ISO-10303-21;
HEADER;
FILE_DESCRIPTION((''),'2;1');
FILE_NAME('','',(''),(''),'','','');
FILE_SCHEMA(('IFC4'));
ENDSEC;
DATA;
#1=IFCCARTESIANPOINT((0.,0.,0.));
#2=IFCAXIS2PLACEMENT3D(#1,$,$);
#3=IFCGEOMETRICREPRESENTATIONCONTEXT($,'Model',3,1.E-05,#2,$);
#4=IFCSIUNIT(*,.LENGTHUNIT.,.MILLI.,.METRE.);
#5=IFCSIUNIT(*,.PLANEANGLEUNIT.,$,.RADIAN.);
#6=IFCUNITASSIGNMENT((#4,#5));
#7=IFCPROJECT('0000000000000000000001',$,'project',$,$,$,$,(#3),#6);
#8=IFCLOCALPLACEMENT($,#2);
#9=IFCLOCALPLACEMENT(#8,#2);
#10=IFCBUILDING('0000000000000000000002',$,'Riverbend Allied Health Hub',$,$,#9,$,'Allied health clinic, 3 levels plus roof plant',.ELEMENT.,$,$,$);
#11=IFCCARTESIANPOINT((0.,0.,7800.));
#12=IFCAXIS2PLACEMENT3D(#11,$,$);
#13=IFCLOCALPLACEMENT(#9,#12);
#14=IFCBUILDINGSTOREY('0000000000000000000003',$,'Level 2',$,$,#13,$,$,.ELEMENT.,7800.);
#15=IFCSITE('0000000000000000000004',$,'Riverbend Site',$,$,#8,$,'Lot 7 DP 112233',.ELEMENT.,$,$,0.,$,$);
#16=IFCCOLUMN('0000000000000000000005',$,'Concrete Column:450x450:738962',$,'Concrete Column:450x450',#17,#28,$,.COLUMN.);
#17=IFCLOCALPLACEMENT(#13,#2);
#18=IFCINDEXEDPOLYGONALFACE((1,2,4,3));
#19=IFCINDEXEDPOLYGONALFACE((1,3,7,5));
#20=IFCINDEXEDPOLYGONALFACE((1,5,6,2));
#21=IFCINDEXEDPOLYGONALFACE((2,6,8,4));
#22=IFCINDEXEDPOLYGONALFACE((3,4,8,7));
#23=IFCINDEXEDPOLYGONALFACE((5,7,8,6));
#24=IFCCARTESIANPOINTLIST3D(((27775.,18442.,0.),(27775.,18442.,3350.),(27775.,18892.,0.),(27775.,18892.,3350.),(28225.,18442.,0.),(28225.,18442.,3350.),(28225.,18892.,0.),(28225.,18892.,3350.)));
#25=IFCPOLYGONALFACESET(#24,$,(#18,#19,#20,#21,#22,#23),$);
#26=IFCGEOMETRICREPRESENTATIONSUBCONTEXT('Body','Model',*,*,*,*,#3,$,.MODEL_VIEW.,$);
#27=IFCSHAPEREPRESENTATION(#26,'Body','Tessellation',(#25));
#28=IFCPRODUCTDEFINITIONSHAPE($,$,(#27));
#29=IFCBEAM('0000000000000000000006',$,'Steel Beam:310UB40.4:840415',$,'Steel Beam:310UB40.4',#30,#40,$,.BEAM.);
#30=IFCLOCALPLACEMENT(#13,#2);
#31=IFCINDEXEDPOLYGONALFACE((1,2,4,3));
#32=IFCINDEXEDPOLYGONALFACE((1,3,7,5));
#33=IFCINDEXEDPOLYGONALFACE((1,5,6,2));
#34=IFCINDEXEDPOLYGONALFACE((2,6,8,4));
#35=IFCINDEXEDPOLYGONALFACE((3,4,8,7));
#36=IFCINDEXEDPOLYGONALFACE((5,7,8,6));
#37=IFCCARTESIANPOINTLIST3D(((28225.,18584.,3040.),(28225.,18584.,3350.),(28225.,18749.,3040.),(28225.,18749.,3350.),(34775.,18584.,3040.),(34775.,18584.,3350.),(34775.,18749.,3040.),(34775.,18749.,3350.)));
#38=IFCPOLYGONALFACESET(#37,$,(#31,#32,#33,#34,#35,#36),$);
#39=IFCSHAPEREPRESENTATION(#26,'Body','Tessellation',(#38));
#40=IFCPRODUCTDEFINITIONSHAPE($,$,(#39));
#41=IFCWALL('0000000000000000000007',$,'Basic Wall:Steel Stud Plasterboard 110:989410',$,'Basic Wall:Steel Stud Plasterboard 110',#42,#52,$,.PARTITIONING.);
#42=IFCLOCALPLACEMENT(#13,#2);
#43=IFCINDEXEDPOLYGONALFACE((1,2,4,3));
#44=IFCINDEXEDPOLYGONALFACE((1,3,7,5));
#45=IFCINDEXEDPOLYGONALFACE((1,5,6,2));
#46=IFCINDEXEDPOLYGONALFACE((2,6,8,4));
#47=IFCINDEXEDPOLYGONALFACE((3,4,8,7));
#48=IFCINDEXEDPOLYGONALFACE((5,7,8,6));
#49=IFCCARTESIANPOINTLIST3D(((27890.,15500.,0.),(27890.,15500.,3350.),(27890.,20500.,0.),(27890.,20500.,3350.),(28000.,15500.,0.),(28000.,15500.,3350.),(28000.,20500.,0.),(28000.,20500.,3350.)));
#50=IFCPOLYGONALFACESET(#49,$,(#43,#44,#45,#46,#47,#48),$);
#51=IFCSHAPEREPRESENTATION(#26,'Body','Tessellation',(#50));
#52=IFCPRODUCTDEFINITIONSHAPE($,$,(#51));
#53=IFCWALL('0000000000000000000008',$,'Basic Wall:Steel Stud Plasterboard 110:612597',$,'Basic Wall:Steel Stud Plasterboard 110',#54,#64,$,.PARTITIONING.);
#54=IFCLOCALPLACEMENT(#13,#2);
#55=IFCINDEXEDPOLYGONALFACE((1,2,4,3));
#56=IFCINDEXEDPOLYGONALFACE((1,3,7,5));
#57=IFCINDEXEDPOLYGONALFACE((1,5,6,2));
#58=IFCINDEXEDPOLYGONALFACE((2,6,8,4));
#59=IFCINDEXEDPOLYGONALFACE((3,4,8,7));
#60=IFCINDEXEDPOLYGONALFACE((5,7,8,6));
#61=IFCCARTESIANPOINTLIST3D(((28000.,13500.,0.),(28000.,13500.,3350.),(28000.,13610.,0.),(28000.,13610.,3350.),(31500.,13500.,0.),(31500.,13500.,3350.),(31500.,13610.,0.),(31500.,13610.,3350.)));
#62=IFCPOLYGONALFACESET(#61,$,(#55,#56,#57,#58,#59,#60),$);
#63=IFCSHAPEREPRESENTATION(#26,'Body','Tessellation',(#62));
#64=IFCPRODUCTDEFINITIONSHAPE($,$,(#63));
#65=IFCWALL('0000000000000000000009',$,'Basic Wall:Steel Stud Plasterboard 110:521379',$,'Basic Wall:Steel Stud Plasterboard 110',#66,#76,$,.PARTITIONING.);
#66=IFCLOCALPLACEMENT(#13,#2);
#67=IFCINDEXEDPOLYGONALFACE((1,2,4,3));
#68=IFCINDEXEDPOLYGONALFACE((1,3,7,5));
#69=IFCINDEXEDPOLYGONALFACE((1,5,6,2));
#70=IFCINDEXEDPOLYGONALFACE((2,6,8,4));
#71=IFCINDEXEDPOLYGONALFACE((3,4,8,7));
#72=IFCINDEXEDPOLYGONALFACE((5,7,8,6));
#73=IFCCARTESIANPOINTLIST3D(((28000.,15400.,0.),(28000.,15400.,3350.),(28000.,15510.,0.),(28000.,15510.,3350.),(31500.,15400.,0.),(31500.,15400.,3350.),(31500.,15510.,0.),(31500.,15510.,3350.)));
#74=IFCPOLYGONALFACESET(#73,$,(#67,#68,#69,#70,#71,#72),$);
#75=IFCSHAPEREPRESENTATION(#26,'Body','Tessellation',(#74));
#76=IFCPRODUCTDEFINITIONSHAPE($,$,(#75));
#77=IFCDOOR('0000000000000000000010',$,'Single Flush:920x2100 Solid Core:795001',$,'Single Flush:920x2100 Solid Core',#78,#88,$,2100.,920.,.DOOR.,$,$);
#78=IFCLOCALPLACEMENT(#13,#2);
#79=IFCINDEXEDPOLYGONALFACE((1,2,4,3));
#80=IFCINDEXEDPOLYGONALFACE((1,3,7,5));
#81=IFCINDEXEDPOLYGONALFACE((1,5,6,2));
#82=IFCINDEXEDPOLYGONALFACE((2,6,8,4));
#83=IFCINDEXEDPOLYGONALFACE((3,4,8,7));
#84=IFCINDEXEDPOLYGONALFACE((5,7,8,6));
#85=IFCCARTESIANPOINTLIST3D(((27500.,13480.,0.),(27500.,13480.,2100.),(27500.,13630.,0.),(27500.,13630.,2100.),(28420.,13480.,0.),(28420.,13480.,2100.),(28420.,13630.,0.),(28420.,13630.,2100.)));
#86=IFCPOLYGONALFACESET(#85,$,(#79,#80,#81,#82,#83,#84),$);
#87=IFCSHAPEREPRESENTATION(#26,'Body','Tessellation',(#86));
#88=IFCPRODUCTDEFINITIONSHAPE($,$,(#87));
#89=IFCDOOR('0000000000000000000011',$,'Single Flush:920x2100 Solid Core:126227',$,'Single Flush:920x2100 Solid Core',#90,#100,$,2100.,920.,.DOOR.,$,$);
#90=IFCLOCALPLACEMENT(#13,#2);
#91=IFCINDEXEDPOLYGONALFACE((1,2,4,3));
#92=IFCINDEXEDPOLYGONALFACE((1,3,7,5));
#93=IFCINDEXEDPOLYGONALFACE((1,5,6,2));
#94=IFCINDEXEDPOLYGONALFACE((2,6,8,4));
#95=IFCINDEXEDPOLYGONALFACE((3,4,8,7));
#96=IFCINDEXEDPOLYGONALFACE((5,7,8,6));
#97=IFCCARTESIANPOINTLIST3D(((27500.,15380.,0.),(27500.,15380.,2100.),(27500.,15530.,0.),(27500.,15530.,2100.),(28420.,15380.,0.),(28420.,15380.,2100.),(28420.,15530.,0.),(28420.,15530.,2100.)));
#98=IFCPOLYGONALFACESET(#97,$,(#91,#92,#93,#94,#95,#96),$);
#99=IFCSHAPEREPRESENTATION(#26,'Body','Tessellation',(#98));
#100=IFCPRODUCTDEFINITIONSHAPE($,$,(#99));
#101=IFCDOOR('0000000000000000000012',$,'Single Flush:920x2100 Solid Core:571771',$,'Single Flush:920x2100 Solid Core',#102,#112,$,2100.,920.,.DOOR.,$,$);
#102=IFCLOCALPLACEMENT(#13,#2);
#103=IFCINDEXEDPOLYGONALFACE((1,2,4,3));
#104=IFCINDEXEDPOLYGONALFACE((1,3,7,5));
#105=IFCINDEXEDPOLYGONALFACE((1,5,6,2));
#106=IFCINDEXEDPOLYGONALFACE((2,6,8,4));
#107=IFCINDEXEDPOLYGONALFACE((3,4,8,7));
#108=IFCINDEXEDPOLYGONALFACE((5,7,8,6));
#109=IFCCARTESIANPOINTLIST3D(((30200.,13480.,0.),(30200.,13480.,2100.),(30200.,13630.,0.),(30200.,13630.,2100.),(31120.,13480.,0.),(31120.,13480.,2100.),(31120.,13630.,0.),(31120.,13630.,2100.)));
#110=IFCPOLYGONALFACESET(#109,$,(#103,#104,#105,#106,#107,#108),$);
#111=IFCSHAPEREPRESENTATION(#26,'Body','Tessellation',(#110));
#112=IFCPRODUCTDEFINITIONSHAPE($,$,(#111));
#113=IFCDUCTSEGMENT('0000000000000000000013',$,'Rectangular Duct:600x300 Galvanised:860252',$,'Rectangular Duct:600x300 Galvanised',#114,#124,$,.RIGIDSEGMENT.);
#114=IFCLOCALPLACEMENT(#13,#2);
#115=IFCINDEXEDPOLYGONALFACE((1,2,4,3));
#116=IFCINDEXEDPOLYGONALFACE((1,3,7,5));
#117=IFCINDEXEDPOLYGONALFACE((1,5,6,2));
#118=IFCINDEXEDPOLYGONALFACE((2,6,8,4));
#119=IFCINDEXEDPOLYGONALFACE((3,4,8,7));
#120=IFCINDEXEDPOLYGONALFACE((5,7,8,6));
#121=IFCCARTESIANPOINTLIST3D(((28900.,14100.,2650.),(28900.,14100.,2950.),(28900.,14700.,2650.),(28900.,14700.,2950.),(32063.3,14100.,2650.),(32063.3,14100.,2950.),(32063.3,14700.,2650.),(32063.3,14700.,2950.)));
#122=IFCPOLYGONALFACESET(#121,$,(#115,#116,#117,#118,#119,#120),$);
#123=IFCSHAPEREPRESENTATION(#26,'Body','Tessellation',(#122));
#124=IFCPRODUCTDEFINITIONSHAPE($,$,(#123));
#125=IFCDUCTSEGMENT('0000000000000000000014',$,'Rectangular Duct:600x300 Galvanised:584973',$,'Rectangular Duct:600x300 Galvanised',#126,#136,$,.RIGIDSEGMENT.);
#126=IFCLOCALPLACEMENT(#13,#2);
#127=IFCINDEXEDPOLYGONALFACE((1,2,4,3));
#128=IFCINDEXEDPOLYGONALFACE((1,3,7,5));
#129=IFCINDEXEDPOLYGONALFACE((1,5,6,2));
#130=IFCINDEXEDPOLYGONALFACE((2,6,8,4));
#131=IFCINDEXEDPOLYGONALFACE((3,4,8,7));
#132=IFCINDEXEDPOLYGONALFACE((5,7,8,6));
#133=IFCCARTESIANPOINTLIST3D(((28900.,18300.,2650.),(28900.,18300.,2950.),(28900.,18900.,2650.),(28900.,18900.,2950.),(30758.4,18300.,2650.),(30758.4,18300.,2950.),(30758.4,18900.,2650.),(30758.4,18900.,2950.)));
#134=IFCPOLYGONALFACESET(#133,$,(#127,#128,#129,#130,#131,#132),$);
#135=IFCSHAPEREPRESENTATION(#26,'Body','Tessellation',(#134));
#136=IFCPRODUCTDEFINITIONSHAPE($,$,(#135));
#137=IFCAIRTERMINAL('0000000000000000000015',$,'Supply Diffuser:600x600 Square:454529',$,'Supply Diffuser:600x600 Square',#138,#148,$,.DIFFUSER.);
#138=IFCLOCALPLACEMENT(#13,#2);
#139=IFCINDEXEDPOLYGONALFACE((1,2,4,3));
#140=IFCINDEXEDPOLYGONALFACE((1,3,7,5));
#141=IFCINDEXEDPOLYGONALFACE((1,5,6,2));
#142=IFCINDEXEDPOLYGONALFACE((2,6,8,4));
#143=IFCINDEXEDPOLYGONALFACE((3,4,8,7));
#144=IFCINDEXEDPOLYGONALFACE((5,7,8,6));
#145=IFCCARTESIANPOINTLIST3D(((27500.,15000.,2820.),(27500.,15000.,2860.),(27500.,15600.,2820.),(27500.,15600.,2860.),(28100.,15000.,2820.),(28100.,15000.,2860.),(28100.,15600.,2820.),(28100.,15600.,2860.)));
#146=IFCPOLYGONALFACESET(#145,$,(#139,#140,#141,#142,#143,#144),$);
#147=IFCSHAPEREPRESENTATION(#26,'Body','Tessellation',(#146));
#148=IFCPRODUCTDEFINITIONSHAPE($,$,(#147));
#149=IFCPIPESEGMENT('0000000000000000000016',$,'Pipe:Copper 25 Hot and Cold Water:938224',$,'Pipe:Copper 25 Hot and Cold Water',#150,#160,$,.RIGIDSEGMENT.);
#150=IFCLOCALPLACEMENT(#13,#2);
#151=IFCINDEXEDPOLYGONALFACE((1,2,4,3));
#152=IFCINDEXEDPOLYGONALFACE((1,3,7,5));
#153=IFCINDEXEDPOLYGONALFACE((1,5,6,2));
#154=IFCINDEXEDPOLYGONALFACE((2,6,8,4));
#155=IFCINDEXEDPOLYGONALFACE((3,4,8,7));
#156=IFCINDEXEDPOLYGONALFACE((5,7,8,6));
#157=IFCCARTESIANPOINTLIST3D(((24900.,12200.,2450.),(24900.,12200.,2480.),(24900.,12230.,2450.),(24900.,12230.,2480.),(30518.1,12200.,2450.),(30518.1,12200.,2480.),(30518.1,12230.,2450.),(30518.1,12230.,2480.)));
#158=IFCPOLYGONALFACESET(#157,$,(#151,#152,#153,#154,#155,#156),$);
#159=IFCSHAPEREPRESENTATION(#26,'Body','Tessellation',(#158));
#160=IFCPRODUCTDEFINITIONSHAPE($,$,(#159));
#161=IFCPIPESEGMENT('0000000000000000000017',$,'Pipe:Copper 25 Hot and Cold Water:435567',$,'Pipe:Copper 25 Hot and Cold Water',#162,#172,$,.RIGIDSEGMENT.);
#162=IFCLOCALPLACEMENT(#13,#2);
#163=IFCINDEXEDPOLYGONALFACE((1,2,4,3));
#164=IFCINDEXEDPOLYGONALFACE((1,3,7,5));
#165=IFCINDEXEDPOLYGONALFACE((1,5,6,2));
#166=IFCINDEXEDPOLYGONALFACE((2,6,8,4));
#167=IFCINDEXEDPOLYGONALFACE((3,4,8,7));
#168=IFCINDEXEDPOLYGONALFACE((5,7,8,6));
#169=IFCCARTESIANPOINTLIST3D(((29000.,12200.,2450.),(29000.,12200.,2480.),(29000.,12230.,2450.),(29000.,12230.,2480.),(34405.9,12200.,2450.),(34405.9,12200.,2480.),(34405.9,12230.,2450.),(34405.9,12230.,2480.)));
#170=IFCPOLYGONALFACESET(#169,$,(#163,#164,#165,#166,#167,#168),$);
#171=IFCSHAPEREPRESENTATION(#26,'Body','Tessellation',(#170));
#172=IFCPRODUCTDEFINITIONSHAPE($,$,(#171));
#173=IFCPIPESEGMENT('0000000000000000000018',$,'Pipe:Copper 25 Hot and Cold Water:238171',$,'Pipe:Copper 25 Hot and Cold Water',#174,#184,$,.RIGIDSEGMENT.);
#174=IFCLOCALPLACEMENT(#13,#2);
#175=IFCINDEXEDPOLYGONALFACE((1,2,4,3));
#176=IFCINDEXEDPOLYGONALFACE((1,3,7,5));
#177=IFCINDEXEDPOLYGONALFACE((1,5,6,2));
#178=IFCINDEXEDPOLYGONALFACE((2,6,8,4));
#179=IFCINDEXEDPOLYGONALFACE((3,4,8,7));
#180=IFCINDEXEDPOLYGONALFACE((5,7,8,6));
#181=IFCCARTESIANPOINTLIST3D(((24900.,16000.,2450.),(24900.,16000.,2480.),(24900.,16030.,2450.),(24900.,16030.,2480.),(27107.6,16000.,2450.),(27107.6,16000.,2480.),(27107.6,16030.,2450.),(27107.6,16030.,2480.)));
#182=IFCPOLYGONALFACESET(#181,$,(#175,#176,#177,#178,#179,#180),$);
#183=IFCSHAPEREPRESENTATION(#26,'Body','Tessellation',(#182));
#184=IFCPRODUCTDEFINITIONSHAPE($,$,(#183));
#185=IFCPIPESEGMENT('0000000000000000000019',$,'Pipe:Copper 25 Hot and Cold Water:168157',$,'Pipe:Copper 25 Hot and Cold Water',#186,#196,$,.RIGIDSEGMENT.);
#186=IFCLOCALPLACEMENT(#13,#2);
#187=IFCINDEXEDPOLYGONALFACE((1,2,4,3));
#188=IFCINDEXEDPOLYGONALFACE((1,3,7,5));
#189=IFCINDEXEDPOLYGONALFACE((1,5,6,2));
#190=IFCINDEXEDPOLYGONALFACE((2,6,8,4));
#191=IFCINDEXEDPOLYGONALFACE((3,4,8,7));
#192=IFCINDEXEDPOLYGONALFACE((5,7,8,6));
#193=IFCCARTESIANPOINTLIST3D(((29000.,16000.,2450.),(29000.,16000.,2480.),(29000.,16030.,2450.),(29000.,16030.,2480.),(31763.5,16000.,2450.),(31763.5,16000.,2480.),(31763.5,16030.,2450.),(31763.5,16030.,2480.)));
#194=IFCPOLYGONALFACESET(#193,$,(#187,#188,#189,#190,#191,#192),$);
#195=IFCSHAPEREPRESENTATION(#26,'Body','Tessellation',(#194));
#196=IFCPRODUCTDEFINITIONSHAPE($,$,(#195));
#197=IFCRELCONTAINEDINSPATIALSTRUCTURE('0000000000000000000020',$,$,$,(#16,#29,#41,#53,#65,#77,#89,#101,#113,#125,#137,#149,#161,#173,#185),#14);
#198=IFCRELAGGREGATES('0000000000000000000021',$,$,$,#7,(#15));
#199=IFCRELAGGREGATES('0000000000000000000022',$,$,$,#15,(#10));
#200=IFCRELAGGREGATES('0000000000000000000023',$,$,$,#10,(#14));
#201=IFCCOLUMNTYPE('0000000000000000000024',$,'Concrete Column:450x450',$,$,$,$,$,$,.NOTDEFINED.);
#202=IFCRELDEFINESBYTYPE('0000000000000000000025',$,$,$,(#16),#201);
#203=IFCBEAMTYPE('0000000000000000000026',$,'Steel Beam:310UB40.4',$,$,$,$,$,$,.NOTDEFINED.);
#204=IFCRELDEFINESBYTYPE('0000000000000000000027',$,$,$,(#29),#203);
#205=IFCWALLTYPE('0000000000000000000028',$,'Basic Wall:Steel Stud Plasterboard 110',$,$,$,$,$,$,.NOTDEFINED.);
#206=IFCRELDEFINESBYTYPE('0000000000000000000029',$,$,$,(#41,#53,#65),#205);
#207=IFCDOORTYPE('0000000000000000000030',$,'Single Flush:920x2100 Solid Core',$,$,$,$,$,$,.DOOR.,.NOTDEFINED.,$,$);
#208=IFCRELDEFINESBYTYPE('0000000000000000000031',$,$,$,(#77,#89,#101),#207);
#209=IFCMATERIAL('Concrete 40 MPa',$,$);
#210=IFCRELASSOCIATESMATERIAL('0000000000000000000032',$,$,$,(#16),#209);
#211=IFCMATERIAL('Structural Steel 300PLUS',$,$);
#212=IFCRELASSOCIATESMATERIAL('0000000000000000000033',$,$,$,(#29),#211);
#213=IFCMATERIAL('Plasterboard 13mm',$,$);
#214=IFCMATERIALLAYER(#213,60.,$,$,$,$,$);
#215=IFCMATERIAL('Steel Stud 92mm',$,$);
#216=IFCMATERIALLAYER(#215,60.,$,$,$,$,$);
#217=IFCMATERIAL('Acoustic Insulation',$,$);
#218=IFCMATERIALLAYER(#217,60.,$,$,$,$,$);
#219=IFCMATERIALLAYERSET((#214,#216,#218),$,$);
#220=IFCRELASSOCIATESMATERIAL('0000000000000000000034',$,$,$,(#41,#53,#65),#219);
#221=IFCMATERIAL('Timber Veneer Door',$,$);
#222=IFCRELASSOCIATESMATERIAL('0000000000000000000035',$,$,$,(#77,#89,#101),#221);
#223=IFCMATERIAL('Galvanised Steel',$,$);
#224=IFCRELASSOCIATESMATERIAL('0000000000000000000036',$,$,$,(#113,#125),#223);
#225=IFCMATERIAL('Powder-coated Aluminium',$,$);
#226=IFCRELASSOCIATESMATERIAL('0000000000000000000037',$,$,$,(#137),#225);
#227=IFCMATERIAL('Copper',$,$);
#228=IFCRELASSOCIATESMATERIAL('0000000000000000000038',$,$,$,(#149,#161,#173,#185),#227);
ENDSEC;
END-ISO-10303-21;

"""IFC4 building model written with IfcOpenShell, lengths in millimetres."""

from ifc_helpers import new_model, si_unit, frame, frame_2d, origin, place, context, subcontext, project, spatial, rectangle, extrude, material, layer, layer_set, layer_usage, type_object, element, save


model = new_model("IFC4")

# Units and contexts
model_context = context("Model", 3, precision=1e-05, world=origin())
body_context = subcontext(model_context, "Body", "Model", "MODEL_VIEW")
ifc_project = project(units=[si_unit("LENGTHUNIT", "METRE", prefix="MILLI"), si_unit("PLANEANGLEUNIT", "RADIAN")], contexts=[model_context])

# Site, building, storey
site_placement = place(None, origin())
site = spatial("IfcSite", under=ifc_project, at=site_placement, Name="Riverbend Site", LongName="Lot 7 DP 112233", CompositionType="ELEMENT", RefElevation=0.0)
building_placement = place(site_placement, origin())
building = spatial("IfcBuilding", under=site, at=building_placement, Name="Riverbend Allied Health Hub", LongName="Allied health clinic, 3 levels plus roof plant", CompositionType="ELEMENT")
storey_placement = place(building_placement, frame((0.0, 0.0, 7800.0)))
storey = spatial("IfcBuildingStorey", under=building, at=storey_placement, Name="Level 2", CompositionType="ELEMENT", Elevation=7800.0)

# Column
ifc_material_1 = material(Name="Concrete 40 MPa")
column_type = type_object("IfcColumnType", Name="Concrete Column:450x450", PredefinedType="NOTDEFINED")
column_placement = place(storey_placement, frame((27775.0, 18442.0, 0.0)))
element("IfcColumn", 1, at=column_placement, inside=storey, type_object=column_type, material=ifc_material_1, Name="Concrete Column:450x450:738962", ObjectType="Concrete Column:450x450", PredefinedType="COLUMN", context=body_context, shape_type="SweptSolid", body=[
    extrude(rectangle(XDim=450.0, YDim=450.0, at=frame_2d((225.0, 225.0))), origin(), (0.0, 0.0, 1.0), 3350.0),
])

# Beam
ifc_material_2 = material(Name="Structural Steel 300PLUS")
beam_type = type_object("IfcBeamType", Name="Steel Beam:310UB40.4", PredefinedType="NOTDEFINED")
beam_placement = place(storey_placement, frame((28225.0, 18584.0, 3040.0)))
element("IfcBeam", 2, at=beam_placement, inside=storey, type_object=beam_type, material=ifc_material_2, Name="Steel Beam:310UB40.4:840415", ObjectType="Steel Beam:310UB40.4", PredefinedType="BEAM", context=body_context, shape_type="SweptSolid", body=[
    extrude(rectangle(XDim=6550.0, YDim=165.0, at=frame_2d((3275.0, 82.5))), origin(), (0.0, 0.0, 1.0), 310.0),
])

# Walls
ifc_material_3 = material(Name="Plasterboard 13mm")
ifc_layer_1 = layer(ifc_material_3, 60.0)
ifc_material_4 = material(Name="Steel Stud 92mm")
ifc_layer_2 = layer(ifc_material_4, 60.0)
ifc_material_5 = material(Name="Acoustic Insulation")
ifc_layer_3 = layer(ifc_material_5, 60.0)
ifc_layer_set = layer_set([ifc_layer_1, ifc_layer_2, ifc_layer_3])
ifc_layer_usage = layer_usage(ifc_layer_set, "AXIS2", "POSITIVE", 0.0)
wall_type = type_object("IfcWallType", Name="Basic Wall:Steel Stud Plasterboard 110", PredefinedType="NOTDEFINED")
wall_placement = place(storey_placement, frame((28000.0, 15500.0, 0.0), z_axis=(0.0, 0.0, 1.0), x_axis=(0.0, 1.0, 0.0)))
element("IfcWall", 3, at=wall_placement, inside=storey, type_object=wall_type, material=ifc_layer_usage, Name="Basic Wall:Steel Stud Plasterboard 110:989410", ObjectType="Basic Wall:Steel Stud Plasterboard 110", PredefinedType="PARTITIONING", context=body_context, shape_type="SweptSolid", body=[
    extrude(rectangle(XDim=5000.0, YDim=110.0, at=frame_2d((2500.0, 55.0))), origin(), (0.0, 0.0, 1.0), 3350.0),
])
for number, where, name in (
    (4, (28000.0, 13500.0, 0.0), "Basic Wall:Steel Stud Plasterboard 110:612597"),
    (5, (28000.0, 15400.0, 0.0), "Basic Wall:Steel Stud Plasterboard 110:521379"),
):
    element("IfcWall", number, at=place(storey_placement, frame(where)), inside=storey, type_object=wall_type, material=ifc_layer_usage, Name=name, ObjectType="Basic Wall:Steel Stud Plasterboard 110", PredefinedType="PARTITIONING", context=body_context, shape_type="SweptSolid", body=[
        extrude(rectangle(XDim=3500.0, YDim=110.0, at=frame_2d((1750.0, 55.0))), origin(), (0.0, 0.0, 1.0), 3350.0),
    ])

# Doors
ifc_material_6 = material(Name="Timber Veneer Door")
door_type = type_object("IfcDoorType", Name="Single Flush:920x2100 Solid Core", OperationType="NOTDEFINED", PredefinedType="DOOR")
for number, where, name in (
    (6, (27500.0, 13480.0, 0.0), "Single Flush:920x2100 Solid Core:795001"),
    (7, (27500.0, 15380.0, 0.0), "Single Flush:920x2100 Solid Core:126227"),
    (8, (30200.0, 13480.0, 0.0), "Single Flush:920x2100 Solid Core:571771"),
):
    element("IfcDoor", number, at=place(storey_placement, frame(where)), inside=storey, type_object=door_type, material=ifc_material_6, Name=name, ObjectType="Single Flush:920x2100 Solid Core", OverallHeight=2100.0, OverallWidth=920.0, PredefinedType="DOOR", context=body_context, shape_type="SweptSolid", body=[
        extrude(rectangle(XDim=920.0, YDim=150.0, at=frame_2d((460.0, 75.0))), origin(), (0.0, 0.0, 1.0), 2100.0),
    ])

# Duct segments
ifc_material_7 = material(Name="Galvanised Steel")
duct_segment_1_placement = place(storey_placement, frame((28900.0, 14100.0, 2650.0)))
element("IfcDuctSegment", 9, at=duct_segment_1_placement, inside=storey, material=ifc_material_7, Name="Rectangular Duct:600x300 Galvanised:860252", ObjectType="Rectangular Duct:600x300 Galvanised", PredefinedType="RIGIDSEGMENT", context=body_context, shape_type="SweptSolid", body=[
    extrude(rectangle(XDim=3163.3, YDim=600.0, at=frame_2d((1581.7, 300.0))), origin(), (0.0, 0.0, 1.0), 300.0),
])
duct_segment_2_placement = place(storey_placement, frame((28900.0, 18300.0, 2650.0)))
element("IfcDuctSegment", 10, at=duct_segment_2_placement, inside=storey, material=ifc_material_7, Name="Rectangular Duct:600x300 Galvanised:584973", ObjectType="Rectangular Duct:600x300 Galvanised", PredefinedType="RIGIDSEGMENT", context=body_context, shape_type="SweptSolid", body=[
    extrude(rectangle(XDim=1858.4, YDim=600.0, at=frame_2d((929.2, 300.0))), origin(), (0.0, 0.0, 1.0), 300.0),
])

# Air terminal
ifc_material_8 = material(Name="Powder-coated Aluminium")
air_terminal_placement = place(storey_placement, frame((27500.0, 15000.0, 2820.0)))
element("IfcAirTerminal", 11, at=air_terminal_placement, inside=storey, material=ifc_material_8, Name="Supply Diffuser:600x600 Square:454529", ObjectType="Supply Diffuser:600x600 Square", PredefinedType="DIFFUSER", context=body_context, shape_type="SweptSolid", body=[
    extrude(rectangle(XDim=600.0, YDim=600.0, at=frame_2d((300.0, 300.0))), origin(), (0.0, 0.0, 1.0), 40.0),
])

# Pipe segments
ifc_material_9 = material(Name="Copper")
pipe_segment_1_placement = place(storey_placement, frame((24900.0, 12200.0, 2450.0)))
element("IfcPipeSegment", 12, at=pipe_segment_1_placement, inside=storey, material=ifc_material_9, Name="Pipe:Copper 25 Hot and Cold Water:938224", ObjectType="Pipe:Copper 25 Hot and Cold Water", PredefinedType="RIGIDSEGMENT", context=body_context, shape_type="SweptSolid", body=[
    extrude(rectangle(XDim=5618.1, YDim=30.0, at=frame_2d((2809.0, 15.0))), origin(), (0.0, 0.0, 1.0), 30.0),
])
pipe_segment_2_placement = place(storey_placement, frame((29000.0, 12200.0, 2450.0)))
element("IfcPipeSegment", 13, at=pipe_segment_2_placement, inside=storey, material=ifc_material_9, Name="Pipe:Copper 25 Hot and Cold Water:435567", ObjectType="Pipe:Copper 25 Hot and Cold Water", PredefinedType="RIGIDSEGMENT", context=body_context, shape_type="SweptSolid", body=[
    extrude(rectangle(XDim=5405.9, YDim=30.0, at=frame_2d((2702.9, 15.0))), origin(), (0.0, 0.0, 1.0), 30.0),
])
pipe_segment_3_placement = place(storey_placement, frame((24900.0, 16000.0, 2450.0)))
element("IfcPipeSegment", 14, at=pipe_segment_3_placement, inside=storey, material=ifc_material_9, Name="Pipe:Copper 25 Hot and Cold Water:238171", ObjectType="Pipe:Copper 25 Hot and Cold Water", PredefinedType="RIGIDSEGMENT", context=body_context, shape_type="SweptSolid", body=[
    extrude(rectangle(XDim=2207.6, YDim=30.0, at=frame_2d((1103.8, 15.0))), origin(), (0.0, 0.0, 1.0), 30.0),
])
pipe_segment_4_placement = place(storey_placement, frame((29000.0, 16000.0, 2450.0)))
element("IfcPipeSegment", 15, at=pipe_segment_4_placement, inside=storey, material=ifc_material_9, Name="Pipe:Copper 25 Hot and Cold Water:168157", ObjectType="Pipe:Copper 25 Hot and Cold Water", PredefinedType="RIGIDSEGMENT", context=body_context, shape_type="SweptSolid", body=[
    extrude(rectangle(XDim=2763.5, YDim=30.0, at=frame_2d((1381.8, 15.0))), origin(), (0.0, 0.0, 1.0), 30.0),
])

save(model, "model.ifc")
